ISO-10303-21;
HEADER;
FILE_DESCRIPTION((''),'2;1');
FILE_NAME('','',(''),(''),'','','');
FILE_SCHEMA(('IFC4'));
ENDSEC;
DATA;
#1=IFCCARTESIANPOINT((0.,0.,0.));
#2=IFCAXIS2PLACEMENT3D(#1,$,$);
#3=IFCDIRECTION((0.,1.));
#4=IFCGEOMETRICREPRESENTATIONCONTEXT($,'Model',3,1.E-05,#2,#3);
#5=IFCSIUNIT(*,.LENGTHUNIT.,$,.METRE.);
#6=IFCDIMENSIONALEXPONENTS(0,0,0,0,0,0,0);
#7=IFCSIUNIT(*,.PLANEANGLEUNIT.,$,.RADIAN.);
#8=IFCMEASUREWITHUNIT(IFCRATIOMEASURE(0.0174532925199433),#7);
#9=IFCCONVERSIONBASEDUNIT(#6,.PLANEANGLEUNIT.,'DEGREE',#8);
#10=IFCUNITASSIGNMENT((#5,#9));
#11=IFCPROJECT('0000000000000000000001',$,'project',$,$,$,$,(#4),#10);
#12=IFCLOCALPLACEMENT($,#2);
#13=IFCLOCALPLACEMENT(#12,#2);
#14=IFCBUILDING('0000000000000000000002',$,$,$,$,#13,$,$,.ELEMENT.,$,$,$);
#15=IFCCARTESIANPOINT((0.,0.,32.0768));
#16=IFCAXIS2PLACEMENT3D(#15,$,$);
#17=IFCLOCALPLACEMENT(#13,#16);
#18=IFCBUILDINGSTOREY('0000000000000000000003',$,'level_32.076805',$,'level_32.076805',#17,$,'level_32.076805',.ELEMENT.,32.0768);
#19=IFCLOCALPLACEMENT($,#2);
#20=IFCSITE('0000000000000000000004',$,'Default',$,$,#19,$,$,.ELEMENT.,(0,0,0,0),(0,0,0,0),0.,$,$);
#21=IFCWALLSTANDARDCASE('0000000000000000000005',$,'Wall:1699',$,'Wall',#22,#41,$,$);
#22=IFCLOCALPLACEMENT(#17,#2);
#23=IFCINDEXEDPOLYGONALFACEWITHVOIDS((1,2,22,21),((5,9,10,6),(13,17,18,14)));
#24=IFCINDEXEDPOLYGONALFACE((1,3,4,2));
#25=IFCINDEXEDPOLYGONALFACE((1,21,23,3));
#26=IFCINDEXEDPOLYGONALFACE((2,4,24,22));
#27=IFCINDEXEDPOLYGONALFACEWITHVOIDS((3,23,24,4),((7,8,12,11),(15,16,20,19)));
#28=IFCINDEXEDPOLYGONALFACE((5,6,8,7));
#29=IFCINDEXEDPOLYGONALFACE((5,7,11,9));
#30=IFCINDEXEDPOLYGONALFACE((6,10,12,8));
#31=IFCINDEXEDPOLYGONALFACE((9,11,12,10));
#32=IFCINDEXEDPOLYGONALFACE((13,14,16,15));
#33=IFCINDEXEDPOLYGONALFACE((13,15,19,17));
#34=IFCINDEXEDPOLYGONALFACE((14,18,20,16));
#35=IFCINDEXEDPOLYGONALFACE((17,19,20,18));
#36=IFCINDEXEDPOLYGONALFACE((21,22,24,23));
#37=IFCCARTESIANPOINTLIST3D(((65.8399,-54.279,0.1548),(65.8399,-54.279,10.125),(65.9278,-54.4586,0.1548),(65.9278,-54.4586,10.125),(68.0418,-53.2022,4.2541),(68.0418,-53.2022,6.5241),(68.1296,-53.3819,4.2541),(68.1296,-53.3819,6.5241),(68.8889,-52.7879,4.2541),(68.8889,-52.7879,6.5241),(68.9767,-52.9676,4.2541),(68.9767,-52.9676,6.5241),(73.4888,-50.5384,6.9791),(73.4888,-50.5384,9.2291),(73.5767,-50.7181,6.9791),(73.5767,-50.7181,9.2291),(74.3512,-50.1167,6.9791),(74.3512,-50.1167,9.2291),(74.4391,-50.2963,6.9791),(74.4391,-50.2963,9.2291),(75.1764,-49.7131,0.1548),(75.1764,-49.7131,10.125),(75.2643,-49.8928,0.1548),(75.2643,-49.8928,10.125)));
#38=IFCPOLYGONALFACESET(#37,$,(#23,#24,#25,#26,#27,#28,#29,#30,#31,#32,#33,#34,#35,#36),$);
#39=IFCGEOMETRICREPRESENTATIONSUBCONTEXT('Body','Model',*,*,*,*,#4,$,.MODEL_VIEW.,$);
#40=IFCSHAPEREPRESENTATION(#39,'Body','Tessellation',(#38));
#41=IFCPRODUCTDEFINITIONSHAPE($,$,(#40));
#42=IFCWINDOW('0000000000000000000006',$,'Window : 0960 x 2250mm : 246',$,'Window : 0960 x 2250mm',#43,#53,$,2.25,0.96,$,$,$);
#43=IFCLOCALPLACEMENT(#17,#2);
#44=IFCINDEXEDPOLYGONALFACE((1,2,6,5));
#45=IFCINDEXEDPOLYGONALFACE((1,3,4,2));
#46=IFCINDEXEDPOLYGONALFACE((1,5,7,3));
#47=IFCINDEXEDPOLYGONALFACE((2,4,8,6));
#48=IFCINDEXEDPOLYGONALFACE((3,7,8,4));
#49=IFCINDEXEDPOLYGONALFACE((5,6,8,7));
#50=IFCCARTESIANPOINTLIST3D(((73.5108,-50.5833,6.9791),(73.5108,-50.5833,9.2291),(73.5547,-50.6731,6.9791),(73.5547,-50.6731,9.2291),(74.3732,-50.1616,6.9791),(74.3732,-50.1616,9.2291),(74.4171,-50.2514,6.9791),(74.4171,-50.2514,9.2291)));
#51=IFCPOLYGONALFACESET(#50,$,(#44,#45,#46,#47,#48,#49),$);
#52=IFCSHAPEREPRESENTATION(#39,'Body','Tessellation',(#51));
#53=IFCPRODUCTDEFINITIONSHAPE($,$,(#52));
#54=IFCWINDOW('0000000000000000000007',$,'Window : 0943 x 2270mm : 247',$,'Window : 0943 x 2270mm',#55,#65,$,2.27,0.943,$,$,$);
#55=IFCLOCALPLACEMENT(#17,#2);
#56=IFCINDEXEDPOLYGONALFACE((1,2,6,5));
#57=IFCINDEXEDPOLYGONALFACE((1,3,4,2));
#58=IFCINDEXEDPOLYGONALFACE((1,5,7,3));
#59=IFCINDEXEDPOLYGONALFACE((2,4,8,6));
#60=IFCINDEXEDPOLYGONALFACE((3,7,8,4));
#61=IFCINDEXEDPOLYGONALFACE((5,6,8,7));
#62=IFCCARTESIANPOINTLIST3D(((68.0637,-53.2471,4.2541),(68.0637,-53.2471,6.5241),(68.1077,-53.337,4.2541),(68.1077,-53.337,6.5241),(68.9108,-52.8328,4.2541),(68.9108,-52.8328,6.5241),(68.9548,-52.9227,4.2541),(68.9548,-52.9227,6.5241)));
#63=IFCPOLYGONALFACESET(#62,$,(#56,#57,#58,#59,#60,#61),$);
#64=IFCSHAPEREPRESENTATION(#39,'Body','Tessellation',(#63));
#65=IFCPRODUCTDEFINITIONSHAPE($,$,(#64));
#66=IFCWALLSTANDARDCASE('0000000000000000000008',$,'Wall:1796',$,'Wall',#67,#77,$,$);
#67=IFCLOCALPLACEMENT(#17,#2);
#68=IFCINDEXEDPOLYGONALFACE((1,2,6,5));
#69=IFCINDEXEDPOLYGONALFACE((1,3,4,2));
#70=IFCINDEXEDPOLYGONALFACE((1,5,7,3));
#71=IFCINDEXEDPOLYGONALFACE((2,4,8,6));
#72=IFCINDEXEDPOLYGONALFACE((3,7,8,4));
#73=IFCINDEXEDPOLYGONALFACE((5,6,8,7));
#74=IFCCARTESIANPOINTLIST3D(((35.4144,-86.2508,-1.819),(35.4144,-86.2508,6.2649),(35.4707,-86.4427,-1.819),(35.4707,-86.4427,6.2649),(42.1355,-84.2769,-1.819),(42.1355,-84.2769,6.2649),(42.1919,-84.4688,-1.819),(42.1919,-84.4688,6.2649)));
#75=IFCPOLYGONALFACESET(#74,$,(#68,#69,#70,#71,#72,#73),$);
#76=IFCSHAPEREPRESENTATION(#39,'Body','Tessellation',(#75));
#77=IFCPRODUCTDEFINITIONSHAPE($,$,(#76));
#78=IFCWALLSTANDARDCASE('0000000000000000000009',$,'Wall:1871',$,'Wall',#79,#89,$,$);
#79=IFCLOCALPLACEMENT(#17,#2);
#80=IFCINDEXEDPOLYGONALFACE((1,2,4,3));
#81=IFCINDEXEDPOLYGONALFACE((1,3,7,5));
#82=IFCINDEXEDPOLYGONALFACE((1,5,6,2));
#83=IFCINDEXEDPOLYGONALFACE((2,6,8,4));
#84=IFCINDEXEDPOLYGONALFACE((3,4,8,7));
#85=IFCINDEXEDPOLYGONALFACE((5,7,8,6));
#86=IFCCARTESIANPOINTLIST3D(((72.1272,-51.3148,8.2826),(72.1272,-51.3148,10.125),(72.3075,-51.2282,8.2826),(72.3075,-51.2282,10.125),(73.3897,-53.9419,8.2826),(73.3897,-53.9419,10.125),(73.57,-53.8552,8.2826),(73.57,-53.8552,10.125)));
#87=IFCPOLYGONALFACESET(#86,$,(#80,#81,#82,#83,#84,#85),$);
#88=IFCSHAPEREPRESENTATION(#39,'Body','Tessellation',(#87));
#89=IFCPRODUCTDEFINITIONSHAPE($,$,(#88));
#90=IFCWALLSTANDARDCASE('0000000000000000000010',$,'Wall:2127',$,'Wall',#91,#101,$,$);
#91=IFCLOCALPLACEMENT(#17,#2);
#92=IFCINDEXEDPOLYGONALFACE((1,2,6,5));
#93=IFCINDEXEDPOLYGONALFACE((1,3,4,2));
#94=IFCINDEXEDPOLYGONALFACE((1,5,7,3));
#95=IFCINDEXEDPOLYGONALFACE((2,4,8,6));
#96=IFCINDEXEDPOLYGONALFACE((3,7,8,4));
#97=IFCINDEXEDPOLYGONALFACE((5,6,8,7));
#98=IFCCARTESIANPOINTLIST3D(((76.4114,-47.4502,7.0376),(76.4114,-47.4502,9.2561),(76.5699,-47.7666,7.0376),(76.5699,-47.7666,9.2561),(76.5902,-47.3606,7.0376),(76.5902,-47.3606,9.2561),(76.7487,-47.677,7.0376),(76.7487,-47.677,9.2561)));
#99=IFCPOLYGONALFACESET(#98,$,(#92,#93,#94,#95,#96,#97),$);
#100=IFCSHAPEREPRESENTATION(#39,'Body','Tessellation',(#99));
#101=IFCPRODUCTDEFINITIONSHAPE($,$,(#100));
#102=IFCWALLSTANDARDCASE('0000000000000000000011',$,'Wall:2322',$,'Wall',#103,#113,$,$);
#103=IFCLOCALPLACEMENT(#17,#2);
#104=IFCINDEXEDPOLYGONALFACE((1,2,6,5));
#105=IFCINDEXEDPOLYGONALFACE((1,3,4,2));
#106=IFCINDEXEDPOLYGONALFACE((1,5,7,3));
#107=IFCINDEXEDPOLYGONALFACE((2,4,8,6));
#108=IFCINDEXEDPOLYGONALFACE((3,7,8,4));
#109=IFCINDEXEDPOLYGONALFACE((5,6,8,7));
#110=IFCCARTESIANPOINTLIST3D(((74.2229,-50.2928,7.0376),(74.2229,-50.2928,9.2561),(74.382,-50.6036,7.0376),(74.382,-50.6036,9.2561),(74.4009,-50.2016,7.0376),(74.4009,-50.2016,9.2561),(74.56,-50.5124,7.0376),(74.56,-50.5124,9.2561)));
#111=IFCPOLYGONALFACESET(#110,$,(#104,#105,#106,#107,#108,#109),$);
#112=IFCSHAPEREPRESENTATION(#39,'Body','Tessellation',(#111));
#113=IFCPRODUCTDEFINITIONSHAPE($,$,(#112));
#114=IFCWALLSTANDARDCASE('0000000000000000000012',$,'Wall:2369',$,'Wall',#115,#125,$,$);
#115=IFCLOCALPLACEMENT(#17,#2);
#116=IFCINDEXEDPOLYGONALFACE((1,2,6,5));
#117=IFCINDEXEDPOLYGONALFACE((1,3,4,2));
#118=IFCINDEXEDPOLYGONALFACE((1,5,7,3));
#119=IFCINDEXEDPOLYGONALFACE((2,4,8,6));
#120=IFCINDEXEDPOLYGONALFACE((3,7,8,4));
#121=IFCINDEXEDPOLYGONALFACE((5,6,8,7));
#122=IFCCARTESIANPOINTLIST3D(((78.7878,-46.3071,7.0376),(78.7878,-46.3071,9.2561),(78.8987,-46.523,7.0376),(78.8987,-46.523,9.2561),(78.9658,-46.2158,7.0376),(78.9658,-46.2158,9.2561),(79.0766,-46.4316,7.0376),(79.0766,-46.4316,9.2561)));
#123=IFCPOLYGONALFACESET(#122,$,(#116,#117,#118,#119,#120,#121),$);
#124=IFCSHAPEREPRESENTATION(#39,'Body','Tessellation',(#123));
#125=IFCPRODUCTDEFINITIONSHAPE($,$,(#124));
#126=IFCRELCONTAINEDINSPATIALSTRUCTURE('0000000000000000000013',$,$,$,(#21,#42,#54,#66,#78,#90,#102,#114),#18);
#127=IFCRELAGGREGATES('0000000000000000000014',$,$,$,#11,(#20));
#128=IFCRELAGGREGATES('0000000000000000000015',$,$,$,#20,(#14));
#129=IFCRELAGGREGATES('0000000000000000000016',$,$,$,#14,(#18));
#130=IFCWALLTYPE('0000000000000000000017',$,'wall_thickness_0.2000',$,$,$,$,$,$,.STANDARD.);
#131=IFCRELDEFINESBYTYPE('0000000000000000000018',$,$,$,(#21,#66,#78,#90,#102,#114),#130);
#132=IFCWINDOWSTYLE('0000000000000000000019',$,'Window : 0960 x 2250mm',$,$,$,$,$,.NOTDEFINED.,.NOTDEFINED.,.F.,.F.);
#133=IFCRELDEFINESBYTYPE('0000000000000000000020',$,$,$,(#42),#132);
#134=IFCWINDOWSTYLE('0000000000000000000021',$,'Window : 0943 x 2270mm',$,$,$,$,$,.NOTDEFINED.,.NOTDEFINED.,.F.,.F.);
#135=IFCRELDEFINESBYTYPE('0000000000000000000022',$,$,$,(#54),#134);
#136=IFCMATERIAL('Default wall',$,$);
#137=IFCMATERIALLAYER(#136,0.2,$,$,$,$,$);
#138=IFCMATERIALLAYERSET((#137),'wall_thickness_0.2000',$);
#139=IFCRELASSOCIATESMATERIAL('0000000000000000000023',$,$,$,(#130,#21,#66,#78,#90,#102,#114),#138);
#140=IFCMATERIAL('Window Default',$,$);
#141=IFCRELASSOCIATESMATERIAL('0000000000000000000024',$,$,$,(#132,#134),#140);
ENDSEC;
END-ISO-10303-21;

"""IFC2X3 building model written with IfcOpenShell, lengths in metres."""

from ifc_helpers import new_model, entity, si_unit, converted_unit, direction, frame, frame_2d, origin, origin_2d_with_axis, place, context, subcontext, project, spatial, polyline, rectangle, outline, extrude, source, transform, mapped, material, layer, layer_set, layer_usage, type_object, type_shapes, element, fill, save


model = new_model("IFC2X3")

# Units and contexts
model_context = context("Model", 3, precision=1e-05, world=origin(), true_north=direction((0.0, 1.0)))
body_context = subcontext(model_context, "Body", "Model", "MODEL_VIEW")
ifc_project = project(units=[si_unit("LENGTHUNIT", "METRE"), converted_unit("PLANEANGLEUNIT", "DEGREE", entity("IfcRatioMeasure", 0.0174532925199433), si_unit("PLANEANGLEUNIT", "RADIAN"), dimensions=[0, 0, 0, 0, 0, 0, 0])], contexts=[model_context])

# Site, building, storey
site_placement = place(None, origin())
site = spatial("IfcSite", under=ifc_project, at=site_placement, Name="Default", CompositionType="ELEMENT", RefLatitude=(0, 0, 0, 0), RefLongitude=(0, 0, 0, 0), RefElevation=0.0)
placement_1 = place(None, origin())
building_placement = place(placement_1, origin())
building = spatial("IfcBuilding", under=site, at=building_placement, CompositionType="ELEMENT")
storey_placement = place(building_placement, frame((0.0, 0.0, 32.0768)))
storey = spatial("IfcBuildingStorey", under=building, at=storey_placement, Name="level_32.076805", ObjectType="level_32.076805", LongName="level_32.076805", CompositionType="ELEMENT", Elevation=32.0768)

# Shared definitions
ifc_material_1 = material(Name="Default wall")
ifc_layer = layer(ifc_material_1, 0.2)
ifc_layer_set = layer_set([ifc_layer], Name="wall_thickness_0.2000")
ifc_layer_usage = layer_usage(ifc_layer_set, "AXIS2", "POSITIVE", -0.1)
wall_type = type_object("IfcWallType", Name="wall_thickness_0.2000", PredefinedType="STANDARD", material=ifc_layer_set)

# Wall, openings, windows
placement_2 = place(building_placement, frame((0.0, 0.0, 32.2316)))
wall_1_placement = place(placement_2, frame((65.8838, -54.3688, 0.0), z_axis=(0.0, 0.0, 1.0), x_axis=(0.898333, 0.439314, 0.0)))
wall_1 = element("IfcWallStandardCase", 1, at=wall_1_placement, inside=storey, type_object=wall_type, material=ifc_layer_usage, Name="Wall:1699", ObjectType="Wall", context=body_context, shape_type="SweptSolid", body=[
    extrude(outline(polyline([(10.3932, -0.1), (10.3932, 0.1), (0.0, 0.1), (0.0, -0.1), (10.3932, -0.1)])), origin(), (0.0, 0.0, 1.0), 9.9701),
])
opening_1_placement = place(wall_1_placement, frame((8.5146, -0.1, 6.8242)))
opening_1 = element("IfcOpeningElement", 2, at=opening_1_placement, cuts=wall_1, ObjectType="Opening", context=body_context, shape_type="SweptSolid", body=[
    extrude(rectangle(XDim=0.96, YDim=2.25, at=frame_2d((1.125, 0.48), x_axis=(0.0, 1.0))), frame((0.0, 0.0, 0.0), z_axis=(0.0, 1.0, 0.0), x_axis=(0.0, 0.0, 1.0)), (0.0, 0.0, 1.0), 0.2),
])
opening_2_placement = place(wall_1_placement, frame((2.451, -0.1, 4.0993)))
opening_2 = element("IfcOpeningElement", 3, at=opening_2_placement, cuts=wall_1, ObjectType="Opening", context=body_context, shape_type="SweptSolid", body=[
    extrude(rectangle(XDim=0.943, YDim=2.27, at=frame_2d((1.135, 0.4715), x_axis=(0.0, 1.0))), frame((0.0, 0.0, 0.0), z_axis=(0.0, 1.0, 0.0), x_axis=(0.0, 0.0, 1.0)), (0.0, 0.0, 1.0), 0.2),
])
ifc_material_2 = material(Name="Window Default")
window_style_1 = type_object("IfcWindowStyle", Name="Window : 0960 x 2250mm", ConstructionType="NOTDEFINED", OperationType="NOTDEFINED", ParameterTakesPrecedence=False, Sizeable=False, material=ifc_material_2)
shared_shape_1 = source(origin(), body_context, "Body", "SweptSolid", [
    extrude(rectangle(XDim=0.1, YDim=0.96, at=origin_2d_with_axis()), frame((0.48, 0.1, 0.0), z_axis=(0.0, 0.0, 1.0), x_axis=(0.0, 1.0, 0.0)), (0.0, 0.0, 1.0), 2.25),
])
type_shapes(window_style_1, [shared_shape_1])
window_1_placement = place(opening_1_placement, origin())
window_1 = element("IfcWindow", 4, at=window_1_placement, inside=storey, type_object=window_style_1, Name="Window : 0960 x 2250mm : 246", ObjectType="Window : 0960 x 2250mm", OverallHeight=2.25, OverallWidth=0.96, context=body_context, shape_type="MappedRepresentation", body=[
    mapped(shared_shape_1, transform((0.0, 0.0, 0.0), scale=1.0)),
])
fill(opening_1, window_1)
window_style_2 = type_object("IfcWindowStyle", Name="Window : 0943 x 2270mm", ConstructionType="NOTDEFINED", OperationType="NOTDEFINED", ParameterTakesPrecedence=False, Sizeable=False, material=ifc_material_2)
shared_shape_2 = source(origin(), body_context, "Body", "SweptSolid", [
    extrude(rectangle(XDim=0.1, YDim=0.943, at=origin_2d_with_axis()), frame((0.4715, 0.1, 0.0), z_axis=(0.0, 0.0, 1.0), x_axis=(0.0, 1.0, 0.0)), (0.0, 0.0, 1.0), 2.27),
])
type_shapes(window_style_2, [shared_shape_2])
window_2_placement = place(opening_2_placement, origin())
window_2 = element("IfcWindow", 5, at=window_2_placement, inside=storey, type_object=window_style_2, Name="Window : 0943 x 2270mm : 247", ObjectType="Window : 0943 x 2270mm", OverallHeight=2.27, OverallWidth=0.943, context=body_context, shape_type="MappedRepresentation", body=[
    mapped(shared_shape_2, transform((0.0, 0.0, 0.0), scale=1.0)),
])
fill(opening_2, window_2)

# Walls
placement_3 = place(building_placement, frame((0.0, 0.0, 30.2578)))
wall_2_placement = place(placement_3, frame((35.4426, -86.3468, 0.0), z_axis=(0.0, 0.0, 1.0), x_axis=(0.959476, 0.281791, 0.0)))
element("IfcWallStandardCase", 6, at=wall_2_placement, inside=storey, type_object=wall_type, material=ifc_layer_usage, Name="Wall:1796", ObjectType="Wall", context=body_context, shape_type="SweptSolid", body=[
    extrude(outline(polyline([(7.005, -0.1), (7.005, 0.1), (0.0, 0.1), (0.0, -0.1), (7.005, -0.1)])), origin(), (0.0, 0.0, 1.0), 8.0839),
])
placement_4 = place(building_placement, frame((0.0, 0.0, 40.3594)))
wall_3_placement = place(placement_4, frame((72.2174, -51.2715, 0.0), z_axis=(0.0, 0.0, 1.0), x_axis=(0.433148, -0.901323, 0.0)))
element("IfcWallStandardCase", 7, at=wall_3_placement, inside=storey, type_object=wall_type, material=ifc_layer_usage, Name="Wall:1871", ObjectType="Wall", context=body_context, shape_type="SweptSolid", body=[
    extrude(outline(polyline([(2.9147, -0.1), (2.9147, 0.1), (0.0, 0.1), (0.0, -0.1), (2.9147, -0.1)])), origin(), (0.0, 0.0, 1.0), 1.8424),
])
placement_5 = place(building_placement, frame((0.0, 0.0, 39.1144)))
wall_4_placement = place(placement_5, frame((76.6593, -47.7218, 0.0), z_axis=(0.0, 0.0, 1.0), x_axis=(-0.447899, 0.894084, 0.0)))
element("IfcWallStandardCase", 8, at=wall_4_placement, inside=storey, type_object=wall_type, material=ifc_layer_usage, Name="Wall:2127", ObjectType="Wall", context=body_context, shape_type="SweptSolid", body=[
    extrude(outline(polyline([(0.3539, -0.1), (0.3539, 0.1), (0.0, 0.1), (0.0, -0.1), (0.3539, -0.1)])), origin(), (0.0, 0.0, 1.0), 2.2184),
])
placement_6 = place(building_placement, frame((0.0, 0.0, 39.1144)))
wall_5_placement = place(placement_6, frame((74.471, -50.558, 0.0), z_axis=(0.0, 0.0, 1.0), x_axis=(-0.455659, 0.890154, 0.0)))
element("IfcWallStandardCase", 9, at=wall_5_placement, inside=storey, type_object=wall_type, material=ifc_layer_usage, Name="Wall:2322", ObjectType="Wall", context=body_context, shape_type="SweptSolid", body=[
    extrude(outline(polyline([(0.3491, -0.1), (0.3491, 0.1), (0.0, 0.1), (0.0, -0.1), (0.3491, -0.1)])), origin(), (0.0, 0.0, 1.0), 2.2184),
])
placement_7 = place(building_placement, frame((0.0, 0.0, 39.1144)))
wall_6_placement = place(placement_7, frame((78.8768, -46.2615, 0.0), z_axis=(0.0, 0.0, 1.0), x_axis=(0.456691, -0.889626, 0.0)))
element("IfcWallStandardCase", 10, at=wall_6_placement, inside=storey, type_object=wall_type, material=ifc_layer_usage, Name="Wall:2369", ObjectType="Wall", context=body_context, shape_type="SweptSolid", body=[
    extrude(outline(polyline([(0.2426, -0.1), (0.2426, 0.1), (0.0, 0.1), (0.0, -0.1), (0.2426, -0.1)])), origin(), (0.0, 0.0, 1.0), 2.2184),
])

save(model, "model.ifc")
